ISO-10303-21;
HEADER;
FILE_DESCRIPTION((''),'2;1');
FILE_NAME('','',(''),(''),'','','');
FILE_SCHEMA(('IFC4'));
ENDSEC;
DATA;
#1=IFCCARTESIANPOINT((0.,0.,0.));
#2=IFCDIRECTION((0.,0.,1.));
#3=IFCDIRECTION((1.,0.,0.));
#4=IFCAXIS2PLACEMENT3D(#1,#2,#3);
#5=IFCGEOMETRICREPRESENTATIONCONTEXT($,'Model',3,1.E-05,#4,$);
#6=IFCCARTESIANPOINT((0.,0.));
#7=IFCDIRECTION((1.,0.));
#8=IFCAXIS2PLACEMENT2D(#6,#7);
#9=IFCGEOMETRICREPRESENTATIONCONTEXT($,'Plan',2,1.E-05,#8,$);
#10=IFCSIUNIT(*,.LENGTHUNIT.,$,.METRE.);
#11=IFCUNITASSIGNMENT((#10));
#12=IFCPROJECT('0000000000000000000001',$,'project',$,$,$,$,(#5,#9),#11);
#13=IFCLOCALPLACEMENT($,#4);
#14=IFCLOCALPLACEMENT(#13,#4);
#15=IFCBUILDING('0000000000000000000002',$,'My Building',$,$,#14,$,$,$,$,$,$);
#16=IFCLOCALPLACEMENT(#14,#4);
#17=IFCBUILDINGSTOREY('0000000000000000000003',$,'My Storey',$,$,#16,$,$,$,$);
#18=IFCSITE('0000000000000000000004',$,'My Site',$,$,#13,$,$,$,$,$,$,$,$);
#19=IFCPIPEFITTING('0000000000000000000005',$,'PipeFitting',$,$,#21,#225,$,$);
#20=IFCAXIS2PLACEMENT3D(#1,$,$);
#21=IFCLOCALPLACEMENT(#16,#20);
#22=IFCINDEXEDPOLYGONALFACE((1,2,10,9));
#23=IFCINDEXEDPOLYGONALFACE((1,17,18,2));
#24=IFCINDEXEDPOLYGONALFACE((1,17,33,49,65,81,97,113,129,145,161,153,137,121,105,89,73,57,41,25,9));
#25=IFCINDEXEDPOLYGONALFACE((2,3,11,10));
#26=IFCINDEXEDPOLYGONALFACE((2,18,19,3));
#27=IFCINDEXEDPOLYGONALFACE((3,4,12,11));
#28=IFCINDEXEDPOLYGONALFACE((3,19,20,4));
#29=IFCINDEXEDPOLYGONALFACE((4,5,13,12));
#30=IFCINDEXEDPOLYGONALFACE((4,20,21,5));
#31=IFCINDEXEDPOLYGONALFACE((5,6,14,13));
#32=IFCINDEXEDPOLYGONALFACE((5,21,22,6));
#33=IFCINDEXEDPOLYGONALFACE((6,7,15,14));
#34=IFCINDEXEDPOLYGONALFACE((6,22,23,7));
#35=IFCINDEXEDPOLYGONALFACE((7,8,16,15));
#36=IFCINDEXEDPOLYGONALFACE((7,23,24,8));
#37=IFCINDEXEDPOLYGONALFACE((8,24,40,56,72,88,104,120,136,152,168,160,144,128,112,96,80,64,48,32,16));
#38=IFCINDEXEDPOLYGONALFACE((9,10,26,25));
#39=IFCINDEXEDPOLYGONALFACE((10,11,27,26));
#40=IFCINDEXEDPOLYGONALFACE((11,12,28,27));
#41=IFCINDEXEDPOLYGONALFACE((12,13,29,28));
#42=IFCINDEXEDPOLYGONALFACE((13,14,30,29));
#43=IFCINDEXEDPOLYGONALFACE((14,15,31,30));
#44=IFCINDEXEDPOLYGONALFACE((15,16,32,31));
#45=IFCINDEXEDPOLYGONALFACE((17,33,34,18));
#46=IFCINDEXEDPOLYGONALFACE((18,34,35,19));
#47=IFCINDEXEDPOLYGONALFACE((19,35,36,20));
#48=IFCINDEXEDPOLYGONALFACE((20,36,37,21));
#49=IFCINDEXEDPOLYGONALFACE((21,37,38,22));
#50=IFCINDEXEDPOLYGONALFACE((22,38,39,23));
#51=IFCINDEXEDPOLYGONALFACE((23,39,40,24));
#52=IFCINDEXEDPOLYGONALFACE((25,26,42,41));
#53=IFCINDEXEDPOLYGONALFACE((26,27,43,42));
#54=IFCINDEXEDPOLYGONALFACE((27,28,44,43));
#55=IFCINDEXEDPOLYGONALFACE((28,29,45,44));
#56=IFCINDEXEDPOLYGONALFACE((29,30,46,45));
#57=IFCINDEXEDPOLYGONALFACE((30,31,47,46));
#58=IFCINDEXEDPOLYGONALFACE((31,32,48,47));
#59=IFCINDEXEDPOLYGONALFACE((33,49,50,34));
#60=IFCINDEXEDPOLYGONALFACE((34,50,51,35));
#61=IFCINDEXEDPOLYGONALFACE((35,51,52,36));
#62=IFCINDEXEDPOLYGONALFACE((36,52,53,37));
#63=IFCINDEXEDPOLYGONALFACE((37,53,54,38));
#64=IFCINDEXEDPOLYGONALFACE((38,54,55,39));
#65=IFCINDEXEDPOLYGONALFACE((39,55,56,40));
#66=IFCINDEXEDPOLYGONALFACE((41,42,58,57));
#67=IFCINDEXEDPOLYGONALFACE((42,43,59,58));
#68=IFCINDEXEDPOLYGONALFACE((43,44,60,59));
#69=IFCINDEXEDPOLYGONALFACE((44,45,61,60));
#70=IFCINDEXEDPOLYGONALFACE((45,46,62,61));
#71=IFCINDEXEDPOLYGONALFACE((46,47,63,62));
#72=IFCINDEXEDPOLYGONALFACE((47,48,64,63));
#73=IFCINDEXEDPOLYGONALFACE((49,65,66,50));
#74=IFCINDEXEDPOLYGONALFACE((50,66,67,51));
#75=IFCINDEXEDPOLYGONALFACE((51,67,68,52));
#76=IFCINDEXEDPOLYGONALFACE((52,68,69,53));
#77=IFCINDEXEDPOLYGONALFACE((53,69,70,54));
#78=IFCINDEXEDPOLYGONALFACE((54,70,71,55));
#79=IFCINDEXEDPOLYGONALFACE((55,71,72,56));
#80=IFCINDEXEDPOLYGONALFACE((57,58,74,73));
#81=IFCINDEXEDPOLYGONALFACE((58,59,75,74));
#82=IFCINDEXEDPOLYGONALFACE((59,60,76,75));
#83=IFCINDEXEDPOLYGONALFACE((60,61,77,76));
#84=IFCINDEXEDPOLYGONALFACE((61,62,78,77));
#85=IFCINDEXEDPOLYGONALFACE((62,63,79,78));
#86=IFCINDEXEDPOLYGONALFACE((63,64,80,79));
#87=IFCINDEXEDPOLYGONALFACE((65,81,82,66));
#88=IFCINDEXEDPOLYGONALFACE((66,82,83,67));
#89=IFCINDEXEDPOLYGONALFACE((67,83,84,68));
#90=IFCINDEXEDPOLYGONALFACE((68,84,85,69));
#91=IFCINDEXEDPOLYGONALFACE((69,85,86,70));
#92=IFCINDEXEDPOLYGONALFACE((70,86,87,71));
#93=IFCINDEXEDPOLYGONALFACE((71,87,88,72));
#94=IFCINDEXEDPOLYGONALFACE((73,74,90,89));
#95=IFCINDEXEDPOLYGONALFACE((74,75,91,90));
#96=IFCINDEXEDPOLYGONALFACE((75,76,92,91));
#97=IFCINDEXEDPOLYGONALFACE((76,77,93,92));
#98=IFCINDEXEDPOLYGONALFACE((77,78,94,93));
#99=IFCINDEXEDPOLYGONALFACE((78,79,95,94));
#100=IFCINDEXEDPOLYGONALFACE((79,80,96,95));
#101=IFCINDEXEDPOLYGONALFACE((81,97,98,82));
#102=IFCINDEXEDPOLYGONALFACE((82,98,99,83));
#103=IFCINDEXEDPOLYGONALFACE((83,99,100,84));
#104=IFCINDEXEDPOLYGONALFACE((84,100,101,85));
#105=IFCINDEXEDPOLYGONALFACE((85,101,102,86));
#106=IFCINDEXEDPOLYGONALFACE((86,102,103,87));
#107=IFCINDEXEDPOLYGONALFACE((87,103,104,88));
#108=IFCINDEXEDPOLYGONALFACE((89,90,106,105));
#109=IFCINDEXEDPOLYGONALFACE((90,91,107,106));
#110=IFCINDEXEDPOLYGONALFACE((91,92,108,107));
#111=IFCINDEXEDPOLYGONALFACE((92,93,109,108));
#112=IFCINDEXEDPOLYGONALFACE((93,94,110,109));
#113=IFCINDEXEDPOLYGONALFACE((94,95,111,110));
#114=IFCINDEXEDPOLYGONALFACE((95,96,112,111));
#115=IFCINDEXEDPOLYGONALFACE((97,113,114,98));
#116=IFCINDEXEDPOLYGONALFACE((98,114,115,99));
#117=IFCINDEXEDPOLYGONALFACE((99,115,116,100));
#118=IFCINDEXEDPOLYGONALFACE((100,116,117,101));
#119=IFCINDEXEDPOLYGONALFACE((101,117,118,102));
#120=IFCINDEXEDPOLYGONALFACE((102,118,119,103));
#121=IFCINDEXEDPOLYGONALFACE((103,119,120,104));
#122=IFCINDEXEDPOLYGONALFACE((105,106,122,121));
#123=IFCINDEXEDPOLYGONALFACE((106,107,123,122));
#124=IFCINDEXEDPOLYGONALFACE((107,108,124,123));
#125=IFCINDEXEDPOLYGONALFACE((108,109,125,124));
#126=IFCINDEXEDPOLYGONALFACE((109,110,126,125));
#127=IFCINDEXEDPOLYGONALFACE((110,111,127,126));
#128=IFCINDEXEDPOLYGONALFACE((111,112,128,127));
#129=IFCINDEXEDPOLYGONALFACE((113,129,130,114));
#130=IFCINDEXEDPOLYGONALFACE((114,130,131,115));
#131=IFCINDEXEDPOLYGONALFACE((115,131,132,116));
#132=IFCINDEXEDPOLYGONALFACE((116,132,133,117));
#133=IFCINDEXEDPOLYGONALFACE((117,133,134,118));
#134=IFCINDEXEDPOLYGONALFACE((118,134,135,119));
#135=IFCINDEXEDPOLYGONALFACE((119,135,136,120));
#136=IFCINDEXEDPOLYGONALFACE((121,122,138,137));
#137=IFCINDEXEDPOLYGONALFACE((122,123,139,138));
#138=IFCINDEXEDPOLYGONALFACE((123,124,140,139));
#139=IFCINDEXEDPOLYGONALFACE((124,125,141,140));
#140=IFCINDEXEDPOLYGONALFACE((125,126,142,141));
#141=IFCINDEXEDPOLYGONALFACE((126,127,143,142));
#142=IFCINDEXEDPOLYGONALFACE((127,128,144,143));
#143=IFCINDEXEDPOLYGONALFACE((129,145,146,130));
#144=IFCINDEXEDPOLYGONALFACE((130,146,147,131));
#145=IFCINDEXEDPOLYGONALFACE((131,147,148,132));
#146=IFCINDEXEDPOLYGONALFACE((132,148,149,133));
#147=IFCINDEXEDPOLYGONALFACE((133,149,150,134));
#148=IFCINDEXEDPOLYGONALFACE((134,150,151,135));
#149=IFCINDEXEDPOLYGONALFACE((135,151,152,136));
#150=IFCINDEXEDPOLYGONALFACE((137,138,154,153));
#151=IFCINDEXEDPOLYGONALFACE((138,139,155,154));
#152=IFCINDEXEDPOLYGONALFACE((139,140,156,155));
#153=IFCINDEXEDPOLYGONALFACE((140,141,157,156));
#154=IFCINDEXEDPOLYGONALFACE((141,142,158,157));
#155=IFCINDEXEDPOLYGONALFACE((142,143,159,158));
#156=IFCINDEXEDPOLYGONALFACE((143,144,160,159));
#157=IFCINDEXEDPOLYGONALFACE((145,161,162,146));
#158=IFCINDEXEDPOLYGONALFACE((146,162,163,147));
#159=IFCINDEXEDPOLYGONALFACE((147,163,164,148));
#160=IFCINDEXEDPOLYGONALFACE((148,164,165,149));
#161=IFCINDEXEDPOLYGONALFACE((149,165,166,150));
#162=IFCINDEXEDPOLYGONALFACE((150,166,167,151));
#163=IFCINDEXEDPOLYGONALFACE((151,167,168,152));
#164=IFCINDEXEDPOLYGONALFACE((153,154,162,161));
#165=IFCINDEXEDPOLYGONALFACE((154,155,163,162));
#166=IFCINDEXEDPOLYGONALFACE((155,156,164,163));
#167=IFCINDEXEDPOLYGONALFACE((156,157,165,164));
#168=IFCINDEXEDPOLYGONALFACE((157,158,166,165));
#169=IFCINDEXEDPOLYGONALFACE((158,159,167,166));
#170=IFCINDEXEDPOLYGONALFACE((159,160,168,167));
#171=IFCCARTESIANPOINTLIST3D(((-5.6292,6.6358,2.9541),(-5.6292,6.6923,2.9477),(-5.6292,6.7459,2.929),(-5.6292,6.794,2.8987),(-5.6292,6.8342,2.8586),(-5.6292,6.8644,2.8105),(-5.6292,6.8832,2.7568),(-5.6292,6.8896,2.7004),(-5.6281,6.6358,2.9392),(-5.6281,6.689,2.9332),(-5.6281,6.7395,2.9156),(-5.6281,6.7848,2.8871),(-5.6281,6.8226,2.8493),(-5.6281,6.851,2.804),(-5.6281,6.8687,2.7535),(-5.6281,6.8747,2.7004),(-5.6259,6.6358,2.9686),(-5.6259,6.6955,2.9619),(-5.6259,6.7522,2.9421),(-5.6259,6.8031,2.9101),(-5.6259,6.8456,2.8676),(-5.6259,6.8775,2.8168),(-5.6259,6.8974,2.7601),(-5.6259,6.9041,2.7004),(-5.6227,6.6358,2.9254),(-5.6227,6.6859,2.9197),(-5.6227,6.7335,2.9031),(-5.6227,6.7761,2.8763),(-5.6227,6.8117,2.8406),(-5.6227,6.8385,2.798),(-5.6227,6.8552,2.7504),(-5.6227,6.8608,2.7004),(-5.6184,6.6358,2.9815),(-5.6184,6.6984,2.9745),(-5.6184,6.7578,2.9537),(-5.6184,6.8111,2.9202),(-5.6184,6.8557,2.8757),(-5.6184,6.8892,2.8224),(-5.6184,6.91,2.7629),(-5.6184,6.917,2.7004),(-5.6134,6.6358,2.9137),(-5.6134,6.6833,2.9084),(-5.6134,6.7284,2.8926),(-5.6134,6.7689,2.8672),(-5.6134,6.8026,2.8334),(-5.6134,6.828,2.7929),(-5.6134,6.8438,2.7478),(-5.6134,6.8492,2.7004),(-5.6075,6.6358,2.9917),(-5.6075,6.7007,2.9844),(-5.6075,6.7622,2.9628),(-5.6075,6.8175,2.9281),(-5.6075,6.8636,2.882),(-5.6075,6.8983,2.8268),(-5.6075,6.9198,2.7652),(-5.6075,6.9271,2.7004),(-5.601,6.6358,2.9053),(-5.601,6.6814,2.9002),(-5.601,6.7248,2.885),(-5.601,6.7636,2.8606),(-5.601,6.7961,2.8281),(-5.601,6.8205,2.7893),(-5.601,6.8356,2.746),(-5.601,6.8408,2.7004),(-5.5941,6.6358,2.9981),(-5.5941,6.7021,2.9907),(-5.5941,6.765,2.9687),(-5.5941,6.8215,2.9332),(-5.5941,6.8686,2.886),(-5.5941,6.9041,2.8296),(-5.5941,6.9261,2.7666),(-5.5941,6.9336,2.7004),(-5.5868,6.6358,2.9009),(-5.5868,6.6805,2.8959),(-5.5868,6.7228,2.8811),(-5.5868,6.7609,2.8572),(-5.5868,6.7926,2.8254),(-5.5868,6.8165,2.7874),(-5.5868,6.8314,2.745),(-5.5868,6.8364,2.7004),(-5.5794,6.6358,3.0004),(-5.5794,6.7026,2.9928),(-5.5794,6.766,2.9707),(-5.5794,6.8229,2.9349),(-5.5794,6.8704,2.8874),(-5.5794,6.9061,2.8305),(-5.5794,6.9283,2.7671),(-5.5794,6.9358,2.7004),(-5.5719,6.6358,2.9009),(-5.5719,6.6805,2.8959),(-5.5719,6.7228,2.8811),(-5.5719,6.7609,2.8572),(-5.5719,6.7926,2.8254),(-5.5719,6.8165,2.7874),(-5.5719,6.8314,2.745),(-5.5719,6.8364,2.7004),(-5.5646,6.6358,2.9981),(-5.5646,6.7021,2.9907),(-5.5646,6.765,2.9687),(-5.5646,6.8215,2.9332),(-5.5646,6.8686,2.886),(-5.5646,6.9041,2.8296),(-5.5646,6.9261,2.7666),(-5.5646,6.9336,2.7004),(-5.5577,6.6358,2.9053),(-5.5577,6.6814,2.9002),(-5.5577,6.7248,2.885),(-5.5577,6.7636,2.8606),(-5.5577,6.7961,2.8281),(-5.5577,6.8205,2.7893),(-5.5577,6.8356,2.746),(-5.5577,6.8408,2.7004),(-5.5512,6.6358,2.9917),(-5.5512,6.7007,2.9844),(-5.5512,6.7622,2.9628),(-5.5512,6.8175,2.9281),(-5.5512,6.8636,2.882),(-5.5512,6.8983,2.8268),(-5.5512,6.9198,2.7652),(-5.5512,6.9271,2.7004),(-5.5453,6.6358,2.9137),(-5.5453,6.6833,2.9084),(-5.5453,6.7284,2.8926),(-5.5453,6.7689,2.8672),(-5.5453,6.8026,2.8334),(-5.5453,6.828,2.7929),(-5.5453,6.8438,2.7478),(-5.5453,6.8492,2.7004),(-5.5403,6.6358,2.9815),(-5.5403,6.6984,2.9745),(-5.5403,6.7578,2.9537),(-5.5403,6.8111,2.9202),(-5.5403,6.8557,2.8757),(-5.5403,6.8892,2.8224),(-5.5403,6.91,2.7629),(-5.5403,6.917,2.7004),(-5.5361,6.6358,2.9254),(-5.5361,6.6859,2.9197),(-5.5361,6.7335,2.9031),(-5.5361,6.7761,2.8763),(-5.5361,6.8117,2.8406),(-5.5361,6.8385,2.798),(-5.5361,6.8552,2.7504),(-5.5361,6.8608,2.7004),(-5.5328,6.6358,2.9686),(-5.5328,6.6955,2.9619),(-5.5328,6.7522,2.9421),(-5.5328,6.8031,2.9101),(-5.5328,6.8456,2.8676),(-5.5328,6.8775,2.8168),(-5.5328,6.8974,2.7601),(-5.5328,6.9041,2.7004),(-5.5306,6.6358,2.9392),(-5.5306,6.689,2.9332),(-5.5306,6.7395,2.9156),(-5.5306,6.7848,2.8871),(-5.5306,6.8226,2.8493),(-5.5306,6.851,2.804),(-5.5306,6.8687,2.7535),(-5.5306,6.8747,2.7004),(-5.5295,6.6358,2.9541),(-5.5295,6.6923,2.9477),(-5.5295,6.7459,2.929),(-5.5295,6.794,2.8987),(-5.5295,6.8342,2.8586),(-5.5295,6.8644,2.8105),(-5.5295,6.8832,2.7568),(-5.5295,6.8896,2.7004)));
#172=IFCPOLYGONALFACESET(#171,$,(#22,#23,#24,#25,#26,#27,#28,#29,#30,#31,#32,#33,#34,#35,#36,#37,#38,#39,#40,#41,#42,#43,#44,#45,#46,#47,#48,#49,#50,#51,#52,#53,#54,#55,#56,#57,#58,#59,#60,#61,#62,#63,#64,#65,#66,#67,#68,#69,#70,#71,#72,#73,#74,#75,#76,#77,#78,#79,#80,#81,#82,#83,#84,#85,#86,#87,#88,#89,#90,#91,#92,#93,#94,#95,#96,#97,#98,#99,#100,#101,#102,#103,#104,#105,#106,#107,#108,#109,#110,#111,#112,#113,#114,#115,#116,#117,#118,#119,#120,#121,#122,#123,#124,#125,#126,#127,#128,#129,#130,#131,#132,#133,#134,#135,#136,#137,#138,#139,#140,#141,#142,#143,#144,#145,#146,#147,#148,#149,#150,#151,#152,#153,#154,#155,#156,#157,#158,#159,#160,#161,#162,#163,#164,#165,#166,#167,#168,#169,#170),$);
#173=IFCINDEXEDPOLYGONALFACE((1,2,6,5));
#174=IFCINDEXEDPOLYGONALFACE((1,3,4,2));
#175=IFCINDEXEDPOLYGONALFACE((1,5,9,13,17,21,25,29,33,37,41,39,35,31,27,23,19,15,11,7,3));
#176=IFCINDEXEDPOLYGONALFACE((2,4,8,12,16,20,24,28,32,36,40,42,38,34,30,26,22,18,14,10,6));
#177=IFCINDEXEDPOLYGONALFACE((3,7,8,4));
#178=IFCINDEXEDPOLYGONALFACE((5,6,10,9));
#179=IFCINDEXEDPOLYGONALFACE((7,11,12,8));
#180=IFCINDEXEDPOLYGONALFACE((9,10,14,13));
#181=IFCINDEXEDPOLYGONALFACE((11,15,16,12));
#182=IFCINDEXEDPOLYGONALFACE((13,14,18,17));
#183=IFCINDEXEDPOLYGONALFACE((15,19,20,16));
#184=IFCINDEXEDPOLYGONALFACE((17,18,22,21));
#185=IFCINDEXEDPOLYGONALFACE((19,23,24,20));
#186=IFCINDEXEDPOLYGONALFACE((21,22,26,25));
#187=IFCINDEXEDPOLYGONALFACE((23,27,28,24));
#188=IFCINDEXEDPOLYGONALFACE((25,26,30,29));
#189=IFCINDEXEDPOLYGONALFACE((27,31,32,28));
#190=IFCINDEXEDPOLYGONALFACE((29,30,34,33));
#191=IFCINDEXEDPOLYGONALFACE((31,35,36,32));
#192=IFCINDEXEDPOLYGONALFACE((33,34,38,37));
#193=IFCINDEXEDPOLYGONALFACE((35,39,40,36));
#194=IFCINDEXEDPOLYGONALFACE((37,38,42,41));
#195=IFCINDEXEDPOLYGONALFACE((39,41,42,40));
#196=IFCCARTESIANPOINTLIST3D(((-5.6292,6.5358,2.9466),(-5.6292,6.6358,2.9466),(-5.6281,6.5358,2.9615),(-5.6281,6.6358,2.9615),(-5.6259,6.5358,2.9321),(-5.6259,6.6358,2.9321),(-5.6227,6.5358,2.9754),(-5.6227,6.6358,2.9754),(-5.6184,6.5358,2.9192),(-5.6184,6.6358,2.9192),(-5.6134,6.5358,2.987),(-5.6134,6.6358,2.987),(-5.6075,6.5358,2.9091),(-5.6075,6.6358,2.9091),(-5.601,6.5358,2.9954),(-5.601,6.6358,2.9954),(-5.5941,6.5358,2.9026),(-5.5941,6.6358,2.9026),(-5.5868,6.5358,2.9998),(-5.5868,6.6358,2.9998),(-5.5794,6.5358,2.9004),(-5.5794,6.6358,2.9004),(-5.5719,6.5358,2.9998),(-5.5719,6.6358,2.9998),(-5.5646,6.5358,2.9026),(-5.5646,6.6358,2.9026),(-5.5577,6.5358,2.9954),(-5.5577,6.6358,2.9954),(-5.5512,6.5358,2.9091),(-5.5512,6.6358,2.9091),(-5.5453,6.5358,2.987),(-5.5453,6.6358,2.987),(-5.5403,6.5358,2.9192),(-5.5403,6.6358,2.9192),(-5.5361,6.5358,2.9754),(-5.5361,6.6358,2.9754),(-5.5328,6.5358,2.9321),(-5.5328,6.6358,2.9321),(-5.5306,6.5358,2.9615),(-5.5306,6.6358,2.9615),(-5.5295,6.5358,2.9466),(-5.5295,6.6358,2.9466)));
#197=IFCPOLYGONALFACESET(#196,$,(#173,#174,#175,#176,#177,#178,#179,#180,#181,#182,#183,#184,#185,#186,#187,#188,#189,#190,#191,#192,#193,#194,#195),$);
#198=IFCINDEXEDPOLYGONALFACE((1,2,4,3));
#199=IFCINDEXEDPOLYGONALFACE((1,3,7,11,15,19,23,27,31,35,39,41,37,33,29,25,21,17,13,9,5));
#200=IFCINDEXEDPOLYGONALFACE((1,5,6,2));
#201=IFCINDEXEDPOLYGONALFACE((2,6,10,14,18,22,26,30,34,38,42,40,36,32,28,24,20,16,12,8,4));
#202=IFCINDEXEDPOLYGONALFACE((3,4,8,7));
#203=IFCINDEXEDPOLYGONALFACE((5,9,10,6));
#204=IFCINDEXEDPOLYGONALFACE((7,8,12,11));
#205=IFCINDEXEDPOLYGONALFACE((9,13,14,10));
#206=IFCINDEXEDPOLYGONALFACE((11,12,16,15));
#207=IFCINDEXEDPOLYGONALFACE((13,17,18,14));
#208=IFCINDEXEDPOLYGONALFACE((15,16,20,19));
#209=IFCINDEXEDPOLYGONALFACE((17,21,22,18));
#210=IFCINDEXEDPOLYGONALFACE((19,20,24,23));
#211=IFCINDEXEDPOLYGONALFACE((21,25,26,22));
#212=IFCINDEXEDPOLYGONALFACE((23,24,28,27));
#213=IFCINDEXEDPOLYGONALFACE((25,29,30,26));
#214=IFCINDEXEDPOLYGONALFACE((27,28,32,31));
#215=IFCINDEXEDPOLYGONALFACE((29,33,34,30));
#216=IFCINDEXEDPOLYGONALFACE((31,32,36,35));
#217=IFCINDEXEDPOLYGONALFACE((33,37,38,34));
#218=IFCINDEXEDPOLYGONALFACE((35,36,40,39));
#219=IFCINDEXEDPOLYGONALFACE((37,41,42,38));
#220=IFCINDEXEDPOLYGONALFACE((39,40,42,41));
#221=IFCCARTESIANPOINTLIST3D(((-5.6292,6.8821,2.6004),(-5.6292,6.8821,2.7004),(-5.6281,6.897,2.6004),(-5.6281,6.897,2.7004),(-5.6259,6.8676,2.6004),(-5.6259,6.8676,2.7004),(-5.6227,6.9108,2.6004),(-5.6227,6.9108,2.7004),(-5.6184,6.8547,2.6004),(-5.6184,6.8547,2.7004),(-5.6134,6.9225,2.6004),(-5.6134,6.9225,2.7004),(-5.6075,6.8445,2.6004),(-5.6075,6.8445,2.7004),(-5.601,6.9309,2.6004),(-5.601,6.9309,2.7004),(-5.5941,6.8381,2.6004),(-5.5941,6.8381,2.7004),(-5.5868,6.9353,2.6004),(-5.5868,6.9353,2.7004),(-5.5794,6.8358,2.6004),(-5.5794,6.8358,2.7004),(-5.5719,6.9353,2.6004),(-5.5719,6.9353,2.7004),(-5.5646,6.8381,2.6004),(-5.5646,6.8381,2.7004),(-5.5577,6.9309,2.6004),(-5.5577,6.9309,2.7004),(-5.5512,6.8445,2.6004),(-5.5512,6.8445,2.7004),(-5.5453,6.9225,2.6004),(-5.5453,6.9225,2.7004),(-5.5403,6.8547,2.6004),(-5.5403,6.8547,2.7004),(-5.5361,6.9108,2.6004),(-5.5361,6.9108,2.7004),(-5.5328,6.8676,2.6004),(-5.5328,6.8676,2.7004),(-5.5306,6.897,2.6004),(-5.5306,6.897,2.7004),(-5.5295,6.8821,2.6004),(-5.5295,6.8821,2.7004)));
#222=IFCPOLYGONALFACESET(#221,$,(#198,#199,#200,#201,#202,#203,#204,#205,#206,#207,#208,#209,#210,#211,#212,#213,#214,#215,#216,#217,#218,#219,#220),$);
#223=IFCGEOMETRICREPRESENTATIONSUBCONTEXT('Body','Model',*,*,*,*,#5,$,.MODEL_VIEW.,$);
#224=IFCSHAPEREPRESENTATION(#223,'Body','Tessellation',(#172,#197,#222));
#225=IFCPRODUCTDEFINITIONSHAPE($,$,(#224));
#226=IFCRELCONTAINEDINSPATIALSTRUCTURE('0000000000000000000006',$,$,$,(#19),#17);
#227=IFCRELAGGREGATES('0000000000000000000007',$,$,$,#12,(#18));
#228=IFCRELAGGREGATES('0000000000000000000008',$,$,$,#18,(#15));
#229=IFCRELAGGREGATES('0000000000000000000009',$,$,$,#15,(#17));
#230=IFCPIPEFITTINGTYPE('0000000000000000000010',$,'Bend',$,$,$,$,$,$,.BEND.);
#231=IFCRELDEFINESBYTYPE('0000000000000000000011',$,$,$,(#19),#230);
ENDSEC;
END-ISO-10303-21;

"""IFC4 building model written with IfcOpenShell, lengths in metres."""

from ifc_helpers import new_model, entity, si_unit, frame, origin_with_axes, origin_2d_with_axis, place, context, subcontext, project, spatial, circle, extrude, source, transform, mapped, type_object, type_shapes, element, save


model = new_model("IFC4")

# Units and contexts
model_context = context("Model", 3, precision=1e-05, world=origin_with_axes())
plan_context = context("Plan", 2, precision=1e-05, world=origin_2d_with_axis())
body_context = subcontext(model_context, "Body", "Model", "MODEL_VIEW")
ifc_project = project(units=[si_unit("LENGTHUNIT", "METRE")], contexts=[model_context, plan_context])

# Site, building, storey
site_placement = place(None, origin_with_axes())
site = spatial("IfcSite", under=ifc_project, at=site_placement, Name="My Site")
building_placement = place(site_placement, origin_with_axes())
building = spatial("IfcBuilding", under=site, at=building_placement, Name="My Building")
storey_placement = place(building_placement, origin_with_axes())
storey = spatial("IfcBuildingStorey", under=building, at=storey_placement, Name="My Storey")

# Pipe fitting
pipe_fitting_type = type_object("IfcPipeFittingType", Name="Bend", PredefinedType="BEND")
shared_shape_1 = source(origin_with_axes(), body_context, "Body", "SolidModel", [
    entity("IfcSweptDiskSolid", entity("IfcIndexedPolyCurve", entity("IfcCartesianPointList3D", [[0.0, 0.0, -0.1], [0.0732, 0.0, -0.2768], [0.25, 0.0, -0.35]]), [entity("IfcArcIndex", [1, 2, 3])]), 0.05),
    extrude(circle(Radius=0.05), origin_with_axes(), (0.0, 0.0, -1.0), 0.1),
    extrude(circle(Radius=0.05), frame((0.25, 0.0, -0.35), z_axis=(1.0, 0.0, 0.0), x_axis=(0.0, 0.0, 1.0)), (0.0, 0.0, 1.0), 0.1),
])
type_shapes(pipe_fitting_type, [shared_shape_1])
for number, where, z_axis, x_axis, name in (
    (1, (-5.5794, 6.5358, 2.9504), (0.0, -1.0, 0.0), (0.0, 0.0, -1.0), "PipeFitting"),
):
    element("IfcPipeFitting", number, at=place(storey_placement, frame(where, z_axis=z_axis, x_axis=x_axis)), inside=storey, type_object=pipe_fitting_type, Name=name, context=body_context, shape_type="MappedRepresentation", body=[
        mapped(shared_shape_1, transform((0.0, 0.0, 0.0), x_axis=(1.0, 0.0, 0.0), y_axis=(0.0, 1.0, 0.0), z_axis=(0.0, 0.0, 1.0), scale=1.0)),
    ])

save(model, "model.ifc")
